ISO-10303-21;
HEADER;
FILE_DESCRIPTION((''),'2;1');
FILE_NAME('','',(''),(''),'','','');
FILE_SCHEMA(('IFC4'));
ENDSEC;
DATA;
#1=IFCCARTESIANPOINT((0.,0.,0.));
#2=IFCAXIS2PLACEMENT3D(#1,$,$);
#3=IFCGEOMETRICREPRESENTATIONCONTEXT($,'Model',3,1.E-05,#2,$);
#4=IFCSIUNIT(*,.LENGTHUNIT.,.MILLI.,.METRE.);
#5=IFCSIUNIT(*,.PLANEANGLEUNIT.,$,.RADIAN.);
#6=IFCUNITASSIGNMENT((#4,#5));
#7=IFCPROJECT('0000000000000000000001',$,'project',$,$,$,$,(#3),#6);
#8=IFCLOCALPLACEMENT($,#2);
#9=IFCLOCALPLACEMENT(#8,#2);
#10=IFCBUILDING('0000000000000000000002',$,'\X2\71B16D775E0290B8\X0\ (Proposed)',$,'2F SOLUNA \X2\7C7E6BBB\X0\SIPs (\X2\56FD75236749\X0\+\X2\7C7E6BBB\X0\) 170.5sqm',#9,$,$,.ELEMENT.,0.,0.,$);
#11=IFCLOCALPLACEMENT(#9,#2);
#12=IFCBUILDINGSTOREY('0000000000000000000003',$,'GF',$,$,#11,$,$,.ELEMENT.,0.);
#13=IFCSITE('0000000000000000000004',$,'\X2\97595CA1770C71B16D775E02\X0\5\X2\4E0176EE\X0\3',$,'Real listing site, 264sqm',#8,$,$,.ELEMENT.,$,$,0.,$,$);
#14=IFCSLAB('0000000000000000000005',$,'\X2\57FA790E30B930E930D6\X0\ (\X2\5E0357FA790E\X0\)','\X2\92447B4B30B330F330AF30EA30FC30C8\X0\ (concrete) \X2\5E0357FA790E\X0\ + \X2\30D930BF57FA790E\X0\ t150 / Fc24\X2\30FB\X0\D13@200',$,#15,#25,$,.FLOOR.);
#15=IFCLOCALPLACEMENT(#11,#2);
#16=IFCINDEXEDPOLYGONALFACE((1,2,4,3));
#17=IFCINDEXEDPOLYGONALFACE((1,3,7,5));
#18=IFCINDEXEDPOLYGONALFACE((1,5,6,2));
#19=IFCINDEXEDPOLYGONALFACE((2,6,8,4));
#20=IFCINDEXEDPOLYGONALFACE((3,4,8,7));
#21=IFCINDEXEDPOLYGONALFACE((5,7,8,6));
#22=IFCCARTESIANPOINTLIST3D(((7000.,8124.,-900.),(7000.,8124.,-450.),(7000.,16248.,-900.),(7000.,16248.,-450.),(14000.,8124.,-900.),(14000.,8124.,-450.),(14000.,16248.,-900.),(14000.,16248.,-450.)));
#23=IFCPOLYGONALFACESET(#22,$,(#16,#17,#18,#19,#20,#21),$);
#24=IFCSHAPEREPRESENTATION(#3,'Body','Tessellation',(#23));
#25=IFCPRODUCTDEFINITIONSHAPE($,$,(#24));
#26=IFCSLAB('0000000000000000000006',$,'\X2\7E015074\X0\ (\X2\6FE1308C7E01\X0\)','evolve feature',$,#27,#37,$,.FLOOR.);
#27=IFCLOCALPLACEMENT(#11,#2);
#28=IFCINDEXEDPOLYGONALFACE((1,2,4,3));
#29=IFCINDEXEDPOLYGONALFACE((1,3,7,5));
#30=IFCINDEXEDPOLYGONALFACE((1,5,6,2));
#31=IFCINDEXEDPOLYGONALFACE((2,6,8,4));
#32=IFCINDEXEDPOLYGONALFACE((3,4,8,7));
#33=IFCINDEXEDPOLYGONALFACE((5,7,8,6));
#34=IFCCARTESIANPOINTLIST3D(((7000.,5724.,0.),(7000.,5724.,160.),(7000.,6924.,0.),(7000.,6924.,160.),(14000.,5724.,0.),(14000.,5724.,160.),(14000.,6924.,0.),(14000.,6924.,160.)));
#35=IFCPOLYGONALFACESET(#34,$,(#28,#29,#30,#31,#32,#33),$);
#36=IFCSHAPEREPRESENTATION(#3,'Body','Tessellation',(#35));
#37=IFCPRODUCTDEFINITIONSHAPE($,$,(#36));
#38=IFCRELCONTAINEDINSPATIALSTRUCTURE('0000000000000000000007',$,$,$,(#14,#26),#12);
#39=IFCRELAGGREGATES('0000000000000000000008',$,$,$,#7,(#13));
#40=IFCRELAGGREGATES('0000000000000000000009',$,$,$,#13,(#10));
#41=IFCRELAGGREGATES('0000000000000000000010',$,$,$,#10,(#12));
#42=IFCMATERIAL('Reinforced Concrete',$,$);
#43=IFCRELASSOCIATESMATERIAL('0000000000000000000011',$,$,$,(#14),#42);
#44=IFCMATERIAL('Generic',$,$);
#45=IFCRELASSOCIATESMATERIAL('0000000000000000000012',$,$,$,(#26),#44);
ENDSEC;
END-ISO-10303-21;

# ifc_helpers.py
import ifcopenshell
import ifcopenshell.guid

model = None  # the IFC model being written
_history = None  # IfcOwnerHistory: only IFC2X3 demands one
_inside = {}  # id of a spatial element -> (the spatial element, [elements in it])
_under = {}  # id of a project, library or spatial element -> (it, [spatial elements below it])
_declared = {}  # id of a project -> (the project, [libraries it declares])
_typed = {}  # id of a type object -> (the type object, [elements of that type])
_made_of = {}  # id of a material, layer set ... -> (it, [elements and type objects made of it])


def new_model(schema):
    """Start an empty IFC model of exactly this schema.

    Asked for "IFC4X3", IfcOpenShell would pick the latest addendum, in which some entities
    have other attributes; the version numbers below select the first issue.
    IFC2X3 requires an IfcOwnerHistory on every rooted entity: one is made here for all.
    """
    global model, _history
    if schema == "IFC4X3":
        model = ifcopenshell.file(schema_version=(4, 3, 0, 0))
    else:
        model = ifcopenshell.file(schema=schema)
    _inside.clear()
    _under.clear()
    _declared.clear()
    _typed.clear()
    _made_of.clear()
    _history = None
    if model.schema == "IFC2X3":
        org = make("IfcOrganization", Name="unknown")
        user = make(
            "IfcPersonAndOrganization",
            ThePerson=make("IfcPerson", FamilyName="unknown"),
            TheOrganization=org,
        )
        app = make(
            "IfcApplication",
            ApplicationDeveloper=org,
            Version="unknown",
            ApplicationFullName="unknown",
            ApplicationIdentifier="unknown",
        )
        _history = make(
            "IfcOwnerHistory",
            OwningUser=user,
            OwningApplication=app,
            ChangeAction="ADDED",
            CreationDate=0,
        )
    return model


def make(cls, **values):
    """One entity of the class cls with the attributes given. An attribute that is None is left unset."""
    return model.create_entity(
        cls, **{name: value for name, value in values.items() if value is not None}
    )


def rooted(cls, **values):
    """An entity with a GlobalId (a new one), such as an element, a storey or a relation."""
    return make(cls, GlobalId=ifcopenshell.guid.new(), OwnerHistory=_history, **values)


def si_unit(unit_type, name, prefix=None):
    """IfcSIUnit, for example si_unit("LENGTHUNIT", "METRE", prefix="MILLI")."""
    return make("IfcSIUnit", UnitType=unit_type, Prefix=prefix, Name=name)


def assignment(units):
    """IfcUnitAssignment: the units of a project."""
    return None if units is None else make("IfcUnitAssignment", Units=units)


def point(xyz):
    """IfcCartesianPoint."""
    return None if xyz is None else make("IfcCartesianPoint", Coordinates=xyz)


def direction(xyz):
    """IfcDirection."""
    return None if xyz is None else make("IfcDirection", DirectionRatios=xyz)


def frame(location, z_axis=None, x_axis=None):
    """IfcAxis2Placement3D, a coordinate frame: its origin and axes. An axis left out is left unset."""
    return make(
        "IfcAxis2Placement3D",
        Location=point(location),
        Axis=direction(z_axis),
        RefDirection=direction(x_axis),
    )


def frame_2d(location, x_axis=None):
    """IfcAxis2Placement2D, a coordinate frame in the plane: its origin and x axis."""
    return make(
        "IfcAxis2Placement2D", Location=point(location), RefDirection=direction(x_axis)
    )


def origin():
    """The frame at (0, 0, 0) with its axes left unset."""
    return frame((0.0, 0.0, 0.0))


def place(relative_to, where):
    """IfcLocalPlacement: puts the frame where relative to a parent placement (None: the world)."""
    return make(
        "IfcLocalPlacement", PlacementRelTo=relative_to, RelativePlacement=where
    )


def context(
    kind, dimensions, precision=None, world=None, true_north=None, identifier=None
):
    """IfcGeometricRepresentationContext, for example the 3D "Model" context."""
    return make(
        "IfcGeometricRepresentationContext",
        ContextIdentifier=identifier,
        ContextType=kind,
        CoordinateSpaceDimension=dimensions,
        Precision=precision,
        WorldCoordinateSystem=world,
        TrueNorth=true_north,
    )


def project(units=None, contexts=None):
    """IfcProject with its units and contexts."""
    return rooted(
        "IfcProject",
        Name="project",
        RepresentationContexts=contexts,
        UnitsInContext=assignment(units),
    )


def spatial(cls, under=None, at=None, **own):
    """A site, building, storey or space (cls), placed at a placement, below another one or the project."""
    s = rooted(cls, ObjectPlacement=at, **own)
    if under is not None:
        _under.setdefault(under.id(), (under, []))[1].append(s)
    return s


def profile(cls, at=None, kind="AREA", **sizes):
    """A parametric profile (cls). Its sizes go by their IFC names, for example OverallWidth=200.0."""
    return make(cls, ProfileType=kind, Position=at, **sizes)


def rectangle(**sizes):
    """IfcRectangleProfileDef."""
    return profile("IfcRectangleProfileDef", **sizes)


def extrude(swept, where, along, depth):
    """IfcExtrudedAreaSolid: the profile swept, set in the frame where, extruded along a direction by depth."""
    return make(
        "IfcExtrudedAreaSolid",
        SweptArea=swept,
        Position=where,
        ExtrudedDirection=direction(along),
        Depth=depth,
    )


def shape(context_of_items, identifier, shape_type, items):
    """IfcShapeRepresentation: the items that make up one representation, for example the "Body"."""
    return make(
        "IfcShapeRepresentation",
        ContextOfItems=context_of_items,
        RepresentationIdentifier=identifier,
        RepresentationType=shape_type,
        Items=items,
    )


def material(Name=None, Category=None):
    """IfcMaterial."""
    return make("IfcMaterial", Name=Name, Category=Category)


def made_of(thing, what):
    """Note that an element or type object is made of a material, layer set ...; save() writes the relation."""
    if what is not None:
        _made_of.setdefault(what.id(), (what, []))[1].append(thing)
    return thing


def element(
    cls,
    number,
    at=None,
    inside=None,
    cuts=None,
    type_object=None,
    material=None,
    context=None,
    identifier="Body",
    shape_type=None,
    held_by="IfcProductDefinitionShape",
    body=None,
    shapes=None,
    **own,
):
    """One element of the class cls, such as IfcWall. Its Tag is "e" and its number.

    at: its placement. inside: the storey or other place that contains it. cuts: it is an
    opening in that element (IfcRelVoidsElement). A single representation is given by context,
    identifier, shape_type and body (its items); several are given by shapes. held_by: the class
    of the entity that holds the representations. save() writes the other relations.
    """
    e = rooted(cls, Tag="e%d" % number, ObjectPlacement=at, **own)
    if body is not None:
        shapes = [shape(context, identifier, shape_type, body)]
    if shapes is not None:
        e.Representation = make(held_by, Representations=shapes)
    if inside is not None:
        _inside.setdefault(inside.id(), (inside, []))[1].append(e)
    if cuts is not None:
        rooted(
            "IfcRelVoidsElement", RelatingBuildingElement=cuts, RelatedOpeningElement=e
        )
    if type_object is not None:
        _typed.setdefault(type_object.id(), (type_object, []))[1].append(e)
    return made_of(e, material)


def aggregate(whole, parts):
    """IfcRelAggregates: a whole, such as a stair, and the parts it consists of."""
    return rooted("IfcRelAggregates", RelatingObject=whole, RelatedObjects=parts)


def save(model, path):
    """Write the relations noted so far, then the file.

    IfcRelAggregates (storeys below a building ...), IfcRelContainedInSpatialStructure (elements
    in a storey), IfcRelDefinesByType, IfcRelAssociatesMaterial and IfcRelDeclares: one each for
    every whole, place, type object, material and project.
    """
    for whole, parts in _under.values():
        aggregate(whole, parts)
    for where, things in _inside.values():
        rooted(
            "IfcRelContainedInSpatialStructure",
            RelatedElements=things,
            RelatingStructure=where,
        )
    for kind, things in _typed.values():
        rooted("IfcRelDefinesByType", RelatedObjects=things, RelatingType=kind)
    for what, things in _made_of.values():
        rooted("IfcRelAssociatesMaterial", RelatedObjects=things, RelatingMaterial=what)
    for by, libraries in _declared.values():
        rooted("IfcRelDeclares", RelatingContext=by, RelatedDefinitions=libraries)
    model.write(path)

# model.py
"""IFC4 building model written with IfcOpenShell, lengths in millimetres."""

from ifc_helpers import new_model, si_unit, frame, frame_2d, origin, place, context, project, spatial, rectangle, extrude, material, element, save


model = new_model("IFC4")

# Units and contexts
model_context = context("Model", 3, precision=1e-05, world=origin())
ifc_project = project(units=[si_unit("LENGTHUNIT", "METRE", prefix="MILLI"), si_unit("PLANEANGLEUNIT", "RADIAN")], contexts=[model_context])

# Site, building, storey
site_placement = place(None, origin())
site = spatial("IfcSite", under=ifc_project, at=site_placement, Name="静岡県熱海市5丁目3", ObjectType="Real listing site, 264sqm", CompositionType="ELEMENT", RefElevation=0.0)
building_placement = place(site_placement, origin())
building = spatial("IfcBuilding", under=site, at=building_placement, Name="熱海市邸 (Proposed)", ObjectType="2F SOLUNA 籾殻SIPs (国産杉+籾殻) 170.5sqm", CompositionType="ELEMENT", ElevationOfRefHeight=0.0, ElevationOfTerrain=0.0)
storey_placement = place(building_placement, origin())
storey = spatial("IfcBuildingStorey", under=building, at=storey_placement, Name="GF", CompositionType="ELEMENT", Elevation=0.0)

# Slabs
ifc_material_1 = material(Name="Reinforced Concrete")
slab_1_placement = place(storey_placement, frame((3500.0, 4062.0, -450.0)))
element("IfcSlab", 1, at=slab_1_placement, inside=storey, material=ifc_material_1, Name="基礎スラブ (布基礎)", Description="鉄筋コンクリート (concrete) 布基礎 + ベタ基礎 t150 / Fc24・D13@200", PredefinedType="FLOOR", context=model_context, shape_type="SweptSolid", body=[
    extrude(rectangle(XDim=7000.0, YDim=8124.0, at=frame_2d((3500.0, 4062.0))), frame((3500.0, 4062.0, -450.0)), (0.0, 0.0, 1.0), 450.0),
])
ifc_material_2 = material(Name="Generic")
slab_2_placement = place(storey_placement, frame((3500.0, 2862.0, 0.0)))
element("IfcSlab", 2, at=slab_2_placement, inside=storey, material=ifc_material_2, Name="縁側 (濡れ縁)", Description="evolve feature", PredefinedType="FLOOR", context=model_context, shape_type="SweptSolid", body=[
    extrude(rectangle(XDim=7000.0, YDim=1200.0, at=frame_2d((3500.0, 600.0))), frame((3500.0, 2862.0, 0.0)), (0.0, 0.0, 1.0), 160.0),
])

save(model, "model.ifc")
